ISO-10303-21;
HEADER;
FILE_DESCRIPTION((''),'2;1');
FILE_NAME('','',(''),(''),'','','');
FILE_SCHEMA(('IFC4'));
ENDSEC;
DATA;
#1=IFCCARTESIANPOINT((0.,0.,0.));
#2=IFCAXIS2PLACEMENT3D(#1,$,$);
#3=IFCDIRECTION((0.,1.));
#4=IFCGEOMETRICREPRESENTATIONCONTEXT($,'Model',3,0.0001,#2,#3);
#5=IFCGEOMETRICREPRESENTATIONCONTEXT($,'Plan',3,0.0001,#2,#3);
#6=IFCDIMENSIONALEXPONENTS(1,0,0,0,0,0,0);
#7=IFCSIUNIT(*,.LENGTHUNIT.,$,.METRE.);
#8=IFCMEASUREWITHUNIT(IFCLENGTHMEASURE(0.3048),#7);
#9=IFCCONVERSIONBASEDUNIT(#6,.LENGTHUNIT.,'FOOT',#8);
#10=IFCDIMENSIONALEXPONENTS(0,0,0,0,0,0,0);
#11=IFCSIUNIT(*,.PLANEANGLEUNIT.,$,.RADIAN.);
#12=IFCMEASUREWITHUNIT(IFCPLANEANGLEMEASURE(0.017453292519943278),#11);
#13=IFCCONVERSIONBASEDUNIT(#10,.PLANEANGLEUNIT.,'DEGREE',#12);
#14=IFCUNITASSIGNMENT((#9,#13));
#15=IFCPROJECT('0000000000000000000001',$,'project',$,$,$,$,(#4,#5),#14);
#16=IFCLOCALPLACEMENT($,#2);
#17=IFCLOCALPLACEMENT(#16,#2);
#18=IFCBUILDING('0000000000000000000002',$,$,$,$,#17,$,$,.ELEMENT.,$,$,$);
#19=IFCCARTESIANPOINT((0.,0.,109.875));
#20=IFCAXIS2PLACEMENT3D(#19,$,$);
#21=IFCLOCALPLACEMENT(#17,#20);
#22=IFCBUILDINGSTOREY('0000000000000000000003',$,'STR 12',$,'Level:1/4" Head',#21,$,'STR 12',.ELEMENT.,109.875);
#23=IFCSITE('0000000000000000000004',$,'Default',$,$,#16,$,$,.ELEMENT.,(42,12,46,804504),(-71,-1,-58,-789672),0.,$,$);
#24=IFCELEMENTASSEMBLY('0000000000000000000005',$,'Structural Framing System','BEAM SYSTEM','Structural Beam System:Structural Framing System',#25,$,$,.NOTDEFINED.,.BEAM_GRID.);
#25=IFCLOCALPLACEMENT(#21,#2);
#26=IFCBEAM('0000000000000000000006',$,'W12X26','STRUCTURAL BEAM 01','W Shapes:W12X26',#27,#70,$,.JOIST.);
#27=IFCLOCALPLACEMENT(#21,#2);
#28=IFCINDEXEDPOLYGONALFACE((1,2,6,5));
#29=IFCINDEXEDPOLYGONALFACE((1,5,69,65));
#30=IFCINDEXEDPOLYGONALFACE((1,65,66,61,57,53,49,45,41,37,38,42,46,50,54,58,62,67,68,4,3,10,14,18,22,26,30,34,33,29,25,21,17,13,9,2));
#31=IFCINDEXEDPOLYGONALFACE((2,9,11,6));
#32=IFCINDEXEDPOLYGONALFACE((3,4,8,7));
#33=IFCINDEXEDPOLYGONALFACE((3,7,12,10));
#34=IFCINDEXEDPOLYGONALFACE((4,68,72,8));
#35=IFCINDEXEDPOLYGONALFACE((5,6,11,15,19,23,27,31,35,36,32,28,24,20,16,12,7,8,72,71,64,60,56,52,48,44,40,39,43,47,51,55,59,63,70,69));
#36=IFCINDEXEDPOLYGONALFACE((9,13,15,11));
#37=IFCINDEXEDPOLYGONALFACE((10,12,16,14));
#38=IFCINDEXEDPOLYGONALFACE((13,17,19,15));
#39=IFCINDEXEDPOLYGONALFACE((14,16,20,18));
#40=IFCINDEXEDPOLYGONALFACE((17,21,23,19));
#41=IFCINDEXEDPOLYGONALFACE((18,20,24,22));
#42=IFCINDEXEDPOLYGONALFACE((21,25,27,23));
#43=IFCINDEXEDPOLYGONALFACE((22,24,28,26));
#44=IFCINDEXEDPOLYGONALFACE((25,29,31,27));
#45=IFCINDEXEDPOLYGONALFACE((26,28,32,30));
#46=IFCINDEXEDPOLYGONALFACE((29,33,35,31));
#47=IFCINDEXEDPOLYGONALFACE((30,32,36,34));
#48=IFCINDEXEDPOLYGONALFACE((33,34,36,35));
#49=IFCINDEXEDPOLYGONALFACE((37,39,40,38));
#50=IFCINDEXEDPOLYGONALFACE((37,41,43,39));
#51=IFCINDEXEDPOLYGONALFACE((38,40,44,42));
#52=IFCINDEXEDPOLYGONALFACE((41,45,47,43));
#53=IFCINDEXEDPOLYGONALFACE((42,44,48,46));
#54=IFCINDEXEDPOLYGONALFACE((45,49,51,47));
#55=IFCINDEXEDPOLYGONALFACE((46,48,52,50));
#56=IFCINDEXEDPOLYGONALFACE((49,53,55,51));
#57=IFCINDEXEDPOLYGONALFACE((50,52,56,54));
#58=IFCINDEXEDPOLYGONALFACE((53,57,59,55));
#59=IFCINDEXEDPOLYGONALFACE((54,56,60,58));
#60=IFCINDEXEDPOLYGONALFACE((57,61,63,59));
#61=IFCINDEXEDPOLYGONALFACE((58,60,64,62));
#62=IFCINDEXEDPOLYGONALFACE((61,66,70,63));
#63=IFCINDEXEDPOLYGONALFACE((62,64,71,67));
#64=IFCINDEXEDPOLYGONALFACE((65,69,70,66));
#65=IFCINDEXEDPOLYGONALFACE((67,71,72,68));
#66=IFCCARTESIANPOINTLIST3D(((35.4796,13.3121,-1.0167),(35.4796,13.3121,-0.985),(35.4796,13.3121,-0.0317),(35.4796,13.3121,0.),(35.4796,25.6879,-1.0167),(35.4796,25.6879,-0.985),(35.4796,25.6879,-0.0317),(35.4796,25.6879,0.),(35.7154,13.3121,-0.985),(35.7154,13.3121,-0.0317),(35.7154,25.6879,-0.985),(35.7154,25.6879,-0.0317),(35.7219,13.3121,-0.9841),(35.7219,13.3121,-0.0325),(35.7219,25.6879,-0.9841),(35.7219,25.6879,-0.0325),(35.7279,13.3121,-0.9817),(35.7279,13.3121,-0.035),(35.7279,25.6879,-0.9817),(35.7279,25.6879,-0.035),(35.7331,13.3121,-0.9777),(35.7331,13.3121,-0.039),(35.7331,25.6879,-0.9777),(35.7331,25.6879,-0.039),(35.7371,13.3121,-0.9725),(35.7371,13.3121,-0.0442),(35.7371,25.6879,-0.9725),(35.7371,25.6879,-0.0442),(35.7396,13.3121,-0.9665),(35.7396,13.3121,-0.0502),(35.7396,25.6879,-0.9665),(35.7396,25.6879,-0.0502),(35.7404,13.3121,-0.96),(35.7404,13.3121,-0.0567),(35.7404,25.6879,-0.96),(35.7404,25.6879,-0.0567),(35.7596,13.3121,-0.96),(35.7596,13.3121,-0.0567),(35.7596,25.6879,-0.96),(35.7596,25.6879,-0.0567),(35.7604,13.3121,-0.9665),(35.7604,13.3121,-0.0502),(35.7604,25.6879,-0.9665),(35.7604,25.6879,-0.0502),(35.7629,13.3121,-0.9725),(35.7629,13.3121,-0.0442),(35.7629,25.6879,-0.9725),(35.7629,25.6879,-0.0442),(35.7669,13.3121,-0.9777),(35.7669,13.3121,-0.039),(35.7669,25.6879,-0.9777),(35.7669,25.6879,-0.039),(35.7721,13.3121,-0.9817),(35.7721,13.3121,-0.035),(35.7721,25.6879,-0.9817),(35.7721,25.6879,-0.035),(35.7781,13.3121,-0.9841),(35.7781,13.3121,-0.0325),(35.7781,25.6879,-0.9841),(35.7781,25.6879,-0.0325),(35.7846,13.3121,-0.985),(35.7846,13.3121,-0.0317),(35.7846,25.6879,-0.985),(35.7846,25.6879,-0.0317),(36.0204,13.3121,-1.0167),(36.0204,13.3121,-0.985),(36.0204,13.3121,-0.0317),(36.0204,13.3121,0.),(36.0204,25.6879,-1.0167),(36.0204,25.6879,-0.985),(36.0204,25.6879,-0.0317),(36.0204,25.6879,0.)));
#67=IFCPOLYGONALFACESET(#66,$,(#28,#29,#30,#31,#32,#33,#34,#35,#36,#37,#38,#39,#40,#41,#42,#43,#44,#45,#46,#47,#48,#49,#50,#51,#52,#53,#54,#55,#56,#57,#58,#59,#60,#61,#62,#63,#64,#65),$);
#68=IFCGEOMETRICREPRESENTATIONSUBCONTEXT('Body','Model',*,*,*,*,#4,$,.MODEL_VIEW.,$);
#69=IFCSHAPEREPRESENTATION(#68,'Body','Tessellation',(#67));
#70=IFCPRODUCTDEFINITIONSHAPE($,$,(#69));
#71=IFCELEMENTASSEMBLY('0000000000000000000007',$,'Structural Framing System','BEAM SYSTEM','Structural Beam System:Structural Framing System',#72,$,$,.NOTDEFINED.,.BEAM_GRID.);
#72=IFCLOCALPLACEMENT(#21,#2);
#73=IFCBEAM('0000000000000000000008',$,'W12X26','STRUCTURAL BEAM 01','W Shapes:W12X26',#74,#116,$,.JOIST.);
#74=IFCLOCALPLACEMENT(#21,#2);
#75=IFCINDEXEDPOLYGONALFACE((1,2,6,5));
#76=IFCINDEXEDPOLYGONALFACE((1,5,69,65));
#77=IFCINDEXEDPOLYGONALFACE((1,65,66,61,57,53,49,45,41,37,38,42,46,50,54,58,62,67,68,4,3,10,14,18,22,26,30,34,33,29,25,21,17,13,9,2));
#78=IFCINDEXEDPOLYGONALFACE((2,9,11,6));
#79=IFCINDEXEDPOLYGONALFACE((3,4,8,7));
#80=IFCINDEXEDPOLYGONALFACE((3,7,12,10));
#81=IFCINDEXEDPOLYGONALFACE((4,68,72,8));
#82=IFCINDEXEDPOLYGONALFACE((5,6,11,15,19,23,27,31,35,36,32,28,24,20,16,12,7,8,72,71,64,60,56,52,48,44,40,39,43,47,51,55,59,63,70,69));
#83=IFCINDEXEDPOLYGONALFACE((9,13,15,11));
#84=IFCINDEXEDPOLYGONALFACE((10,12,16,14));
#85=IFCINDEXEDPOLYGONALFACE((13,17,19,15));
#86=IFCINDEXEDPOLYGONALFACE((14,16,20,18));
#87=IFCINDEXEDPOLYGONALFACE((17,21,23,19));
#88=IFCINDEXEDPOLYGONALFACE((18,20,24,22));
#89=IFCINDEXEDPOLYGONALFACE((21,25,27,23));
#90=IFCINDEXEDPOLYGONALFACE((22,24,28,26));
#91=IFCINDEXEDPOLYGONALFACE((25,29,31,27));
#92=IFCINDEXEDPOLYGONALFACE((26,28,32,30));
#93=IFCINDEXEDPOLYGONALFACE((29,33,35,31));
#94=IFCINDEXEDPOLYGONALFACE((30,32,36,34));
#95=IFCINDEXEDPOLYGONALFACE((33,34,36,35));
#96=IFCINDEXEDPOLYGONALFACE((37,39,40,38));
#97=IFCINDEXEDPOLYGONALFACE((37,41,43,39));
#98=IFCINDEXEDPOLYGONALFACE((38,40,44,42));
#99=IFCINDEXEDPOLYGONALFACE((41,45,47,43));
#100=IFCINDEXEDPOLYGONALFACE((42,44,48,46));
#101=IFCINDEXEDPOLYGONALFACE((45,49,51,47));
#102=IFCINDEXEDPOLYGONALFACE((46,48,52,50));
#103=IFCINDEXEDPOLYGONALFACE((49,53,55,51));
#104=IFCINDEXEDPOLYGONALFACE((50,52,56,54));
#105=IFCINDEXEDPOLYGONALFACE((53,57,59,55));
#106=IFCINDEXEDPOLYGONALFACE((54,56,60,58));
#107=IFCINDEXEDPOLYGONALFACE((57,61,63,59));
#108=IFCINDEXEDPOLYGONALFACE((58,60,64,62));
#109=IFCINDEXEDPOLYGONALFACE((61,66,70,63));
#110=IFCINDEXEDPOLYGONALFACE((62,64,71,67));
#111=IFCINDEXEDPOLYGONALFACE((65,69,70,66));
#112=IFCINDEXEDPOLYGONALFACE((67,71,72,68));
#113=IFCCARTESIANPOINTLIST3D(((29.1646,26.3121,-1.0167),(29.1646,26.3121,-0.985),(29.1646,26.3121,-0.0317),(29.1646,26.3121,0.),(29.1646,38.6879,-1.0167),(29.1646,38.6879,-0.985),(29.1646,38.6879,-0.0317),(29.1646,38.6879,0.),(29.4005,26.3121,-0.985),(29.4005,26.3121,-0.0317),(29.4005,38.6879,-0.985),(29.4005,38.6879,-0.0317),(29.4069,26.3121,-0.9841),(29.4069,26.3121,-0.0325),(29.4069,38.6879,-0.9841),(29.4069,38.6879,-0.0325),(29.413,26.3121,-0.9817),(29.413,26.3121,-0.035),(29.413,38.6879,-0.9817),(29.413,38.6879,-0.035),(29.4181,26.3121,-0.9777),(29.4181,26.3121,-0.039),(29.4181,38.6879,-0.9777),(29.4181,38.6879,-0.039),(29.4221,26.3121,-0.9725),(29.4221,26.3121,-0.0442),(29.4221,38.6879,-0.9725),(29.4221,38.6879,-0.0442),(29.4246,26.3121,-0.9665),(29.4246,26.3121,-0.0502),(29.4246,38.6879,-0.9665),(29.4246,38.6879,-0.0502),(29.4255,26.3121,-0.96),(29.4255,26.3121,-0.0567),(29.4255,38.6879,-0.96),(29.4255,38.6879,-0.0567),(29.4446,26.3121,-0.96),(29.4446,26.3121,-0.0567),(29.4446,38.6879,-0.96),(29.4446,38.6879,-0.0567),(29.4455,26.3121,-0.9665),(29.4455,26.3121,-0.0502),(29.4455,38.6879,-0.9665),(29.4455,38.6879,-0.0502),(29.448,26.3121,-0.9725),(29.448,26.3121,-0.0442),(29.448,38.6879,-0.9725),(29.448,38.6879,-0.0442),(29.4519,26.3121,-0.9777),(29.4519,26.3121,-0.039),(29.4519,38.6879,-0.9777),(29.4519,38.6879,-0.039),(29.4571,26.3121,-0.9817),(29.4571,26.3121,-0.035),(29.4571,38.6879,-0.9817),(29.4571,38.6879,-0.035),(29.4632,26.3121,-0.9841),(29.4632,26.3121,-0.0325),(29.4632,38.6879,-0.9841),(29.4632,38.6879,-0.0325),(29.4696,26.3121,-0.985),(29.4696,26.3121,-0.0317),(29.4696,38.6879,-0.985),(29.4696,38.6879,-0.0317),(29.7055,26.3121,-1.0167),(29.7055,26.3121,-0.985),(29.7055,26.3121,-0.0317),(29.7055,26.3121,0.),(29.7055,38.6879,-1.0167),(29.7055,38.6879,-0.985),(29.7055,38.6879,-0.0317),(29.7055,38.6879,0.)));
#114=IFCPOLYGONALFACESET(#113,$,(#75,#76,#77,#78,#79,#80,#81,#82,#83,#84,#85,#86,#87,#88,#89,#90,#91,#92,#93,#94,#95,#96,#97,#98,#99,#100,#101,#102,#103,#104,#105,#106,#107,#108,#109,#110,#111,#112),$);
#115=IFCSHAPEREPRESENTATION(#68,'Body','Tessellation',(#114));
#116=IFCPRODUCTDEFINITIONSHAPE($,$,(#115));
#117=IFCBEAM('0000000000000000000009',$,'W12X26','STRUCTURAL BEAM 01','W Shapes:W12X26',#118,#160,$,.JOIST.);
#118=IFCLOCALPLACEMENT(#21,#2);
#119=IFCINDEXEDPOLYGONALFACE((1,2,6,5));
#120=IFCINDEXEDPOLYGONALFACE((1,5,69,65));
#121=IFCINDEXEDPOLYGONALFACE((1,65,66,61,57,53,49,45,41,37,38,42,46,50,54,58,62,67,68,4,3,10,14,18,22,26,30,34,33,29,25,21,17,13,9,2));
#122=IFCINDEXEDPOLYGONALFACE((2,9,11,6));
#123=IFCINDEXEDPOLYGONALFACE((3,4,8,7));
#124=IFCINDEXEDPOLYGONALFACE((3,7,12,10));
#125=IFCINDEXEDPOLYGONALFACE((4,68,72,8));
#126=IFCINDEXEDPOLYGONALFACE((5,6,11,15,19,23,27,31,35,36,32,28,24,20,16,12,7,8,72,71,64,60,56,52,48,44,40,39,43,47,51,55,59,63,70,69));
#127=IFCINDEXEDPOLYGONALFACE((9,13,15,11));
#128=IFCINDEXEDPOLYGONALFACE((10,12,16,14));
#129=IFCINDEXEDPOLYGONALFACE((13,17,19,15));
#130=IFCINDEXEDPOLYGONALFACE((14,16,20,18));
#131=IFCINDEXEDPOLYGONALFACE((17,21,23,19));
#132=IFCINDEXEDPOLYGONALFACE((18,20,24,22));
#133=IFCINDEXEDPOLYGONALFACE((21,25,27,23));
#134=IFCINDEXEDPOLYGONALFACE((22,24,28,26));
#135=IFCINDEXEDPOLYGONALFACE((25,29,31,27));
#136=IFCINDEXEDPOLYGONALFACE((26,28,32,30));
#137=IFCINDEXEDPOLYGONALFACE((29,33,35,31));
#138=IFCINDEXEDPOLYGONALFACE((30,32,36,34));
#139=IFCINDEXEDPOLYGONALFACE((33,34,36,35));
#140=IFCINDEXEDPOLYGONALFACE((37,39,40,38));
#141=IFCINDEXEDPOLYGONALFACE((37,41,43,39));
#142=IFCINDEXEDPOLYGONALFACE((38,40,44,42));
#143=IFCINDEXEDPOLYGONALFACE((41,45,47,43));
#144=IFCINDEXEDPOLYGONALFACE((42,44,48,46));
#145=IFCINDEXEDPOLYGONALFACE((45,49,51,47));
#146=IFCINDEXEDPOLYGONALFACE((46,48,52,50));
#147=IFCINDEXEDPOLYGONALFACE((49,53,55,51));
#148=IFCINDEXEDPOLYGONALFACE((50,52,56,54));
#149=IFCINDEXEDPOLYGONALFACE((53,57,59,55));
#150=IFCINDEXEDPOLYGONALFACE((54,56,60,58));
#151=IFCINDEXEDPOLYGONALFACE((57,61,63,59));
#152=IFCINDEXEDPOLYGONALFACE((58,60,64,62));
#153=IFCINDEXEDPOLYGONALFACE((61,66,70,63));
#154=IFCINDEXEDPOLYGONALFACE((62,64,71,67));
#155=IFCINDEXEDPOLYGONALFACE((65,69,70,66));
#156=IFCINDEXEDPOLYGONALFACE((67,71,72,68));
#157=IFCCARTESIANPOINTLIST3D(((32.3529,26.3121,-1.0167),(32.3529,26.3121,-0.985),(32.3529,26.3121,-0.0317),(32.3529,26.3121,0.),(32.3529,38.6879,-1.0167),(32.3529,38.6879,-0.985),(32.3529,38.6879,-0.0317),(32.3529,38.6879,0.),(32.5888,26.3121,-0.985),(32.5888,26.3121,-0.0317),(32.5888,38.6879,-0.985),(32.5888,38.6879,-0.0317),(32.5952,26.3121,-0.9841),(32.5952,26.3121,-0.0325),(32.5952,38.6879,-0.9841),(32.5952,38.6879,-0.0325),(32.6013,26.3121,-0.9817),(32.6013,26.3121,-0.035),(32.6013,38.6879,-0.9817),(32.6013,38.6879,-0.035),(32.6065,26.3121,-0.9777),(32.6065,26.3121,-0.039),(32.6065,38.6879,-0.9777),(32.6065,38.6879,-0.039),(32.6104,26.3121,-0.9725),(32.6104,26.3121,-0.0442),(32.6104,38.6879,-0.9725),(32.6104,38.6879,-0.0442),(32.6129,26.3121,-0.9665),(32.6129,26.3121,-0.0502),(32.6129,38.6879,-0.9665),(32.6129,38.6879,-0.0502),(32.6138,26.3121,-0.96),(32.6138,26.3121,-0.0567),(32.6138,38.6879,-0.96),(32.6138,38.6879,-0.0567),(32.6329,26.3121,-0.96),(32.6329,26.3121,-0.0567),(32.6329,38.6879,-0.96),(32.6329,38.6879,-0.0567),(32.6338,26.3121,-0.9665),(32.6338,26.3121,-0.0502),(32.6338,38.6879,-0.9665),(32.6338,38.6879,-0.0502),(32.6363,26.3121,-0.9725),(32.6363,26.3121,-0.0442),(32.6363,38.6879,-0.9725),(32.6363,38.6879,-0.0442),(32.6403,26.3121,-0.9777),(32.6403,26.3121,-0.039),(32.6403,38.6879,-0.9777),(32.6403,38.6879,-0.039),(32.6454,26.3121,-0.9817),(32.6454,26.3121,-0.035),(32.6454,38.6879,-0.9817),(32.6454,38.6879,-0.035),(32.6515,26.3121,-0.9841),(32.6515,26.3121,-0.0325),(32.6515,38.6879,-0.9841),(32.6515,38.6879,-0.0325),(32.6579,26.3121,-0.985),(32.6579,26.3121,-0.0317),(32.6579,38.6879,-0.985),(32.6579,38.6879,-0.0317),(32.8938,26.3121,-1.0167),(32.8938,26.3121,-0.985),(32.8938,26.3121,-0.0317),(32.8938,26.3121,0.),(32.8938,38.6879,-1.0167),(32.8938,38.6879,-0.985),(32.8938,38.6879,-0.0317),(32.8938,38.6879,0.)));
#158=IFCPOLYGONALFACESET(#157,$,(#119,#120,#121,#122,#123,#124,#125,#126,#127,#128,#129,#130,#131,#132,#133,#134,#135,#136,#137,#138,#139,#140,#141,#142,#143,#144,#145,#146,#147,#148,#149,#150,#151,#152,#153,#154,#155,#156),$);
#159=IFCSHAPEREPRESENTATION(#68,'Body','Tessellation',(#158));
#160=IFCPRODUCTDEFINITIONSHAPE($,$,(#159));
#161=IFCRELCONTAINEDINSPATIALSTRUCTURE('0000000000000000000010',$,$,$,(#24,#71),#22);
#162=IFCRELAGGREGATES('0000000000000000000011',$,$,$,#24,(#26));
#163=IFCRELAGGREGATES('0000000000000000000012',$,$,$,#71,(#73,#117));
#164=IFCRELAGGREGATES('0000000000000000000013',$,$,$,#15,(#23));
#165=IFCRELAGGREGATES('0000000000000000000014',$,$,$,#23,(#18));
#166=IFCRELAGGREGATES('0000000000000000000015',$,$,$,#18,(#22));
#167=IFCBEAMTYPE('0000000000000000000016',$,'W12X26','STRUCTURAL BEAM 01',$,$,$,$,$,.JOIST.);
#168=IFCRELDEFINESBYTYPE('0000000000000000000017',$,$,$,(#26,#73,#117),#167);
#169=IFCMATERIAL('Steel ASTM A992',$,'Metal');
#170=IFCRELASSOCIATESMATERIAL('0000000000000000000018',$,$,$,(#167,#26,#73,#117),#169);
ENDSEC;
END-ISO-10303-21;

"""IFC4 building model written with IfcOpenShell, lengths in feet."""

from ifc_helpers import new_model, entity, si_unit, converted_unit, direction, frame, origin, place, context, subcontext, project, spatial, line, arc, indexed_curve, outline, extrude, source, transform, mapped, material, type_object, type_shapes, element, aggregate, save


model = new_model("IFC4")

# Units and contexts
model_context = context("Model", 3, precision=0.0001, world=origin(), true_north=direction((0.0, 1.0)))
plan_context = context("Plan", 3, precision=0.0001, world=origin(), true_north=direction((0.0, 1.0)))
body_context = subcontext(model_context, "Body", "Model", "MODEL_VIEW")
ifc_project = project(units=[converted_unit("LENGTHUNIT", "FOOT", entity("IfcLengthMeasure", 0.3048), si_unit("LENGTHUNIT", "METRE"), dimensions=[1, 0, 0, 0, 0, 0, 0]), converted_unit("PLANEANGLEUNIT", "DEGREE", entity("IfcPlaneAngleMeasure", 0.017453292519943278), si_unit("PLANEANGLEUNIT", "RADIAN"), dimensions=[0, 0, 0, 0, 0, 0, 0])], contexts=[model_context, plan_context])

# Site, building, storey
site_placement = place(None, origin())
site = spatial("IfcSite", under=ifc_project, at=site_placement, Name="Default", CompositionType="ELEMENT", RefLatitude=(42, 12, 46, 804504), RefLongitude=(-71, -1, -58, -789672), RefElevation=0.0)
building_placement = place(site_placement, origin())
building = spatial("IfcBuilding", under=site, at=building_placement, CompositionType="ELEMENT")
storey_placement = place(building_placement, frame((0.0, 0.0, 109.875)))
storey = spatial("IfcBuildingStorey", under=building, at=storey_placement, Name="STR 12", ObjectType="Level:1/4\" Head", LongName="STR 12", CompositionType="ELEMENT", Elevation=109.875)

# Element assemblies, beams
ifc_material = material(Name="Steel ASTM A992", Category="Metal")
beam_type = type_object("IfcBeamType", Name="W12X26", Description="STRUCTURAL BEAM 01", PredefinedType="JOIST", material=ifc_material)
shared_shape = source(origin(), body_context, "Body", "SweptSolid", [
    extrude(outline(indexed_curve([(-0.2704, -0.4767), (-0.2704, -0.5083), (0.2704, -0.5083), (0.2704, -0.4767), (0.0346, -0.4767), (0.0169, -0.4693), (0.0096, -0.4517), (0.0096, 0.4517), (0.0169, 0.4693), (0.0346, 0.4767), (0.2704, 0.4767), (0.2704, 0.5083), (-0.2704, 0.5083), (-0.2704, 0.4767), (-0.0346, 0.4767), (-0.0169, 0.4693), (-0.0096, 0.4517), (-0.0096, -0.4517), (-0.0169, -0.4693), (-0.0346, -0.4767)], segments=[line(1, 2, 3, 4, 5), arc(5, 6, 7), line(7, 8), arc(8, 9, 10), line(10, 11, 12, 13, 14, 15), arc(15, 16, 17), line(17, 18), arc(18, 19, 20), line(20, 1)], self_intersect=False)), frame((-6.1879, 0.0, 0.0), z_axis=(-1.0, 0.0, 0.0), x_axis=(0.0, -1.0, 0.0)), (0.0, 0.0, -1.0), 12.3758),
])
type_shapes(beam_type, [shared_shape])
assembly_1_placement = place(storey_placement, origin())
assembly_1 = element("IfcElementAssembly", 1, at=assembly_1_placement, inside=storey, Name="Structural Framing System", Description="BEAM SYSTEM", ObjectType="Structural Beam System:Structural Framing System", AssemblyPlace="NOTDEFINED", PredefinedType="BEAM_GRID")
beam_1_placement = place(assembly_1_placement, frame((35.75, 19.5, -0.5083), z_axis=(0.0, 0.0, 1.0), x_axis=(0.0, 1.0, 0.0)))
beam_1 = element("IfcBeam", 2, at=beam_1_placement, type_object=beam_type, material=ifc_material, Name="W12X26", Description="STRUCTURAL BEAM 01", ObjectType="W Shapes:W12X26", PredefinedType="JOIST", context=body_context, shape_type="MappedRepresentation", body=[
    mapped(shared_shape, transform((0.0, 0.0, 0.0), scale=1.0)),
])
aggregate(assembly_1, [beam_1])
assembly_2_placement = place(storey_placement, origin())
assembly_2 = element("IfcElementAssembly", 3, at=assembly_2_placement, inside=storey, Name="Structural Framing System", Description="BEAM SYSTEM", ObjectType="Structural Beam System:Structural Framing System", AssemblyPlace="NOTDEFINED", PredefinedType="BEAM_GRID")
beam_2_placement = place(assembly_2_placement, frame((29.435, 32.5, -0.5083), z_axis=(0.0, 0.0, 1.0), x_axis=(0.0, 1.0, 0.0)))
beam_2 = element("IfcBeam", 4, at=beam_2_placement, type_object=beam_type, material=ifc_material, Name="W12X26", Description="STRUCTURAL BEAM 01", ObjectType="W Shapes:W12X26", PredefinedType="JOIST", context=body_context, shape_type="MappedRepresentation", body=[
    mapped(shared_shape, transform((0.0, 0.0, 0.0), scale=1.0)),
])
beam_3_placement = place(assembly_2_placement, frame((32.6234, 32.5, -0.5083), z_axis=(0.0, 0.0, 1.0), x_axis=(0.0, 1.0, 0.0)))
beam_3 = element("IfcBeam", 5, at=beam_3_placement, type_object=beam_type, material=ifc_material, Name="W12X26", Description="STRUCTURAL BEAM 01", ObjectType="W Shapes:W12X26", PredefinedType="JOIST", context=body_context, shape_type="MappedRepresentation", body=[
    mapped(shared_shape, transform((0.0, 0.0, 0.0), scale=1.0)),
])
aggregate(assembly_2, [beam_2, beam_3])

save(model, "model.ifc")
